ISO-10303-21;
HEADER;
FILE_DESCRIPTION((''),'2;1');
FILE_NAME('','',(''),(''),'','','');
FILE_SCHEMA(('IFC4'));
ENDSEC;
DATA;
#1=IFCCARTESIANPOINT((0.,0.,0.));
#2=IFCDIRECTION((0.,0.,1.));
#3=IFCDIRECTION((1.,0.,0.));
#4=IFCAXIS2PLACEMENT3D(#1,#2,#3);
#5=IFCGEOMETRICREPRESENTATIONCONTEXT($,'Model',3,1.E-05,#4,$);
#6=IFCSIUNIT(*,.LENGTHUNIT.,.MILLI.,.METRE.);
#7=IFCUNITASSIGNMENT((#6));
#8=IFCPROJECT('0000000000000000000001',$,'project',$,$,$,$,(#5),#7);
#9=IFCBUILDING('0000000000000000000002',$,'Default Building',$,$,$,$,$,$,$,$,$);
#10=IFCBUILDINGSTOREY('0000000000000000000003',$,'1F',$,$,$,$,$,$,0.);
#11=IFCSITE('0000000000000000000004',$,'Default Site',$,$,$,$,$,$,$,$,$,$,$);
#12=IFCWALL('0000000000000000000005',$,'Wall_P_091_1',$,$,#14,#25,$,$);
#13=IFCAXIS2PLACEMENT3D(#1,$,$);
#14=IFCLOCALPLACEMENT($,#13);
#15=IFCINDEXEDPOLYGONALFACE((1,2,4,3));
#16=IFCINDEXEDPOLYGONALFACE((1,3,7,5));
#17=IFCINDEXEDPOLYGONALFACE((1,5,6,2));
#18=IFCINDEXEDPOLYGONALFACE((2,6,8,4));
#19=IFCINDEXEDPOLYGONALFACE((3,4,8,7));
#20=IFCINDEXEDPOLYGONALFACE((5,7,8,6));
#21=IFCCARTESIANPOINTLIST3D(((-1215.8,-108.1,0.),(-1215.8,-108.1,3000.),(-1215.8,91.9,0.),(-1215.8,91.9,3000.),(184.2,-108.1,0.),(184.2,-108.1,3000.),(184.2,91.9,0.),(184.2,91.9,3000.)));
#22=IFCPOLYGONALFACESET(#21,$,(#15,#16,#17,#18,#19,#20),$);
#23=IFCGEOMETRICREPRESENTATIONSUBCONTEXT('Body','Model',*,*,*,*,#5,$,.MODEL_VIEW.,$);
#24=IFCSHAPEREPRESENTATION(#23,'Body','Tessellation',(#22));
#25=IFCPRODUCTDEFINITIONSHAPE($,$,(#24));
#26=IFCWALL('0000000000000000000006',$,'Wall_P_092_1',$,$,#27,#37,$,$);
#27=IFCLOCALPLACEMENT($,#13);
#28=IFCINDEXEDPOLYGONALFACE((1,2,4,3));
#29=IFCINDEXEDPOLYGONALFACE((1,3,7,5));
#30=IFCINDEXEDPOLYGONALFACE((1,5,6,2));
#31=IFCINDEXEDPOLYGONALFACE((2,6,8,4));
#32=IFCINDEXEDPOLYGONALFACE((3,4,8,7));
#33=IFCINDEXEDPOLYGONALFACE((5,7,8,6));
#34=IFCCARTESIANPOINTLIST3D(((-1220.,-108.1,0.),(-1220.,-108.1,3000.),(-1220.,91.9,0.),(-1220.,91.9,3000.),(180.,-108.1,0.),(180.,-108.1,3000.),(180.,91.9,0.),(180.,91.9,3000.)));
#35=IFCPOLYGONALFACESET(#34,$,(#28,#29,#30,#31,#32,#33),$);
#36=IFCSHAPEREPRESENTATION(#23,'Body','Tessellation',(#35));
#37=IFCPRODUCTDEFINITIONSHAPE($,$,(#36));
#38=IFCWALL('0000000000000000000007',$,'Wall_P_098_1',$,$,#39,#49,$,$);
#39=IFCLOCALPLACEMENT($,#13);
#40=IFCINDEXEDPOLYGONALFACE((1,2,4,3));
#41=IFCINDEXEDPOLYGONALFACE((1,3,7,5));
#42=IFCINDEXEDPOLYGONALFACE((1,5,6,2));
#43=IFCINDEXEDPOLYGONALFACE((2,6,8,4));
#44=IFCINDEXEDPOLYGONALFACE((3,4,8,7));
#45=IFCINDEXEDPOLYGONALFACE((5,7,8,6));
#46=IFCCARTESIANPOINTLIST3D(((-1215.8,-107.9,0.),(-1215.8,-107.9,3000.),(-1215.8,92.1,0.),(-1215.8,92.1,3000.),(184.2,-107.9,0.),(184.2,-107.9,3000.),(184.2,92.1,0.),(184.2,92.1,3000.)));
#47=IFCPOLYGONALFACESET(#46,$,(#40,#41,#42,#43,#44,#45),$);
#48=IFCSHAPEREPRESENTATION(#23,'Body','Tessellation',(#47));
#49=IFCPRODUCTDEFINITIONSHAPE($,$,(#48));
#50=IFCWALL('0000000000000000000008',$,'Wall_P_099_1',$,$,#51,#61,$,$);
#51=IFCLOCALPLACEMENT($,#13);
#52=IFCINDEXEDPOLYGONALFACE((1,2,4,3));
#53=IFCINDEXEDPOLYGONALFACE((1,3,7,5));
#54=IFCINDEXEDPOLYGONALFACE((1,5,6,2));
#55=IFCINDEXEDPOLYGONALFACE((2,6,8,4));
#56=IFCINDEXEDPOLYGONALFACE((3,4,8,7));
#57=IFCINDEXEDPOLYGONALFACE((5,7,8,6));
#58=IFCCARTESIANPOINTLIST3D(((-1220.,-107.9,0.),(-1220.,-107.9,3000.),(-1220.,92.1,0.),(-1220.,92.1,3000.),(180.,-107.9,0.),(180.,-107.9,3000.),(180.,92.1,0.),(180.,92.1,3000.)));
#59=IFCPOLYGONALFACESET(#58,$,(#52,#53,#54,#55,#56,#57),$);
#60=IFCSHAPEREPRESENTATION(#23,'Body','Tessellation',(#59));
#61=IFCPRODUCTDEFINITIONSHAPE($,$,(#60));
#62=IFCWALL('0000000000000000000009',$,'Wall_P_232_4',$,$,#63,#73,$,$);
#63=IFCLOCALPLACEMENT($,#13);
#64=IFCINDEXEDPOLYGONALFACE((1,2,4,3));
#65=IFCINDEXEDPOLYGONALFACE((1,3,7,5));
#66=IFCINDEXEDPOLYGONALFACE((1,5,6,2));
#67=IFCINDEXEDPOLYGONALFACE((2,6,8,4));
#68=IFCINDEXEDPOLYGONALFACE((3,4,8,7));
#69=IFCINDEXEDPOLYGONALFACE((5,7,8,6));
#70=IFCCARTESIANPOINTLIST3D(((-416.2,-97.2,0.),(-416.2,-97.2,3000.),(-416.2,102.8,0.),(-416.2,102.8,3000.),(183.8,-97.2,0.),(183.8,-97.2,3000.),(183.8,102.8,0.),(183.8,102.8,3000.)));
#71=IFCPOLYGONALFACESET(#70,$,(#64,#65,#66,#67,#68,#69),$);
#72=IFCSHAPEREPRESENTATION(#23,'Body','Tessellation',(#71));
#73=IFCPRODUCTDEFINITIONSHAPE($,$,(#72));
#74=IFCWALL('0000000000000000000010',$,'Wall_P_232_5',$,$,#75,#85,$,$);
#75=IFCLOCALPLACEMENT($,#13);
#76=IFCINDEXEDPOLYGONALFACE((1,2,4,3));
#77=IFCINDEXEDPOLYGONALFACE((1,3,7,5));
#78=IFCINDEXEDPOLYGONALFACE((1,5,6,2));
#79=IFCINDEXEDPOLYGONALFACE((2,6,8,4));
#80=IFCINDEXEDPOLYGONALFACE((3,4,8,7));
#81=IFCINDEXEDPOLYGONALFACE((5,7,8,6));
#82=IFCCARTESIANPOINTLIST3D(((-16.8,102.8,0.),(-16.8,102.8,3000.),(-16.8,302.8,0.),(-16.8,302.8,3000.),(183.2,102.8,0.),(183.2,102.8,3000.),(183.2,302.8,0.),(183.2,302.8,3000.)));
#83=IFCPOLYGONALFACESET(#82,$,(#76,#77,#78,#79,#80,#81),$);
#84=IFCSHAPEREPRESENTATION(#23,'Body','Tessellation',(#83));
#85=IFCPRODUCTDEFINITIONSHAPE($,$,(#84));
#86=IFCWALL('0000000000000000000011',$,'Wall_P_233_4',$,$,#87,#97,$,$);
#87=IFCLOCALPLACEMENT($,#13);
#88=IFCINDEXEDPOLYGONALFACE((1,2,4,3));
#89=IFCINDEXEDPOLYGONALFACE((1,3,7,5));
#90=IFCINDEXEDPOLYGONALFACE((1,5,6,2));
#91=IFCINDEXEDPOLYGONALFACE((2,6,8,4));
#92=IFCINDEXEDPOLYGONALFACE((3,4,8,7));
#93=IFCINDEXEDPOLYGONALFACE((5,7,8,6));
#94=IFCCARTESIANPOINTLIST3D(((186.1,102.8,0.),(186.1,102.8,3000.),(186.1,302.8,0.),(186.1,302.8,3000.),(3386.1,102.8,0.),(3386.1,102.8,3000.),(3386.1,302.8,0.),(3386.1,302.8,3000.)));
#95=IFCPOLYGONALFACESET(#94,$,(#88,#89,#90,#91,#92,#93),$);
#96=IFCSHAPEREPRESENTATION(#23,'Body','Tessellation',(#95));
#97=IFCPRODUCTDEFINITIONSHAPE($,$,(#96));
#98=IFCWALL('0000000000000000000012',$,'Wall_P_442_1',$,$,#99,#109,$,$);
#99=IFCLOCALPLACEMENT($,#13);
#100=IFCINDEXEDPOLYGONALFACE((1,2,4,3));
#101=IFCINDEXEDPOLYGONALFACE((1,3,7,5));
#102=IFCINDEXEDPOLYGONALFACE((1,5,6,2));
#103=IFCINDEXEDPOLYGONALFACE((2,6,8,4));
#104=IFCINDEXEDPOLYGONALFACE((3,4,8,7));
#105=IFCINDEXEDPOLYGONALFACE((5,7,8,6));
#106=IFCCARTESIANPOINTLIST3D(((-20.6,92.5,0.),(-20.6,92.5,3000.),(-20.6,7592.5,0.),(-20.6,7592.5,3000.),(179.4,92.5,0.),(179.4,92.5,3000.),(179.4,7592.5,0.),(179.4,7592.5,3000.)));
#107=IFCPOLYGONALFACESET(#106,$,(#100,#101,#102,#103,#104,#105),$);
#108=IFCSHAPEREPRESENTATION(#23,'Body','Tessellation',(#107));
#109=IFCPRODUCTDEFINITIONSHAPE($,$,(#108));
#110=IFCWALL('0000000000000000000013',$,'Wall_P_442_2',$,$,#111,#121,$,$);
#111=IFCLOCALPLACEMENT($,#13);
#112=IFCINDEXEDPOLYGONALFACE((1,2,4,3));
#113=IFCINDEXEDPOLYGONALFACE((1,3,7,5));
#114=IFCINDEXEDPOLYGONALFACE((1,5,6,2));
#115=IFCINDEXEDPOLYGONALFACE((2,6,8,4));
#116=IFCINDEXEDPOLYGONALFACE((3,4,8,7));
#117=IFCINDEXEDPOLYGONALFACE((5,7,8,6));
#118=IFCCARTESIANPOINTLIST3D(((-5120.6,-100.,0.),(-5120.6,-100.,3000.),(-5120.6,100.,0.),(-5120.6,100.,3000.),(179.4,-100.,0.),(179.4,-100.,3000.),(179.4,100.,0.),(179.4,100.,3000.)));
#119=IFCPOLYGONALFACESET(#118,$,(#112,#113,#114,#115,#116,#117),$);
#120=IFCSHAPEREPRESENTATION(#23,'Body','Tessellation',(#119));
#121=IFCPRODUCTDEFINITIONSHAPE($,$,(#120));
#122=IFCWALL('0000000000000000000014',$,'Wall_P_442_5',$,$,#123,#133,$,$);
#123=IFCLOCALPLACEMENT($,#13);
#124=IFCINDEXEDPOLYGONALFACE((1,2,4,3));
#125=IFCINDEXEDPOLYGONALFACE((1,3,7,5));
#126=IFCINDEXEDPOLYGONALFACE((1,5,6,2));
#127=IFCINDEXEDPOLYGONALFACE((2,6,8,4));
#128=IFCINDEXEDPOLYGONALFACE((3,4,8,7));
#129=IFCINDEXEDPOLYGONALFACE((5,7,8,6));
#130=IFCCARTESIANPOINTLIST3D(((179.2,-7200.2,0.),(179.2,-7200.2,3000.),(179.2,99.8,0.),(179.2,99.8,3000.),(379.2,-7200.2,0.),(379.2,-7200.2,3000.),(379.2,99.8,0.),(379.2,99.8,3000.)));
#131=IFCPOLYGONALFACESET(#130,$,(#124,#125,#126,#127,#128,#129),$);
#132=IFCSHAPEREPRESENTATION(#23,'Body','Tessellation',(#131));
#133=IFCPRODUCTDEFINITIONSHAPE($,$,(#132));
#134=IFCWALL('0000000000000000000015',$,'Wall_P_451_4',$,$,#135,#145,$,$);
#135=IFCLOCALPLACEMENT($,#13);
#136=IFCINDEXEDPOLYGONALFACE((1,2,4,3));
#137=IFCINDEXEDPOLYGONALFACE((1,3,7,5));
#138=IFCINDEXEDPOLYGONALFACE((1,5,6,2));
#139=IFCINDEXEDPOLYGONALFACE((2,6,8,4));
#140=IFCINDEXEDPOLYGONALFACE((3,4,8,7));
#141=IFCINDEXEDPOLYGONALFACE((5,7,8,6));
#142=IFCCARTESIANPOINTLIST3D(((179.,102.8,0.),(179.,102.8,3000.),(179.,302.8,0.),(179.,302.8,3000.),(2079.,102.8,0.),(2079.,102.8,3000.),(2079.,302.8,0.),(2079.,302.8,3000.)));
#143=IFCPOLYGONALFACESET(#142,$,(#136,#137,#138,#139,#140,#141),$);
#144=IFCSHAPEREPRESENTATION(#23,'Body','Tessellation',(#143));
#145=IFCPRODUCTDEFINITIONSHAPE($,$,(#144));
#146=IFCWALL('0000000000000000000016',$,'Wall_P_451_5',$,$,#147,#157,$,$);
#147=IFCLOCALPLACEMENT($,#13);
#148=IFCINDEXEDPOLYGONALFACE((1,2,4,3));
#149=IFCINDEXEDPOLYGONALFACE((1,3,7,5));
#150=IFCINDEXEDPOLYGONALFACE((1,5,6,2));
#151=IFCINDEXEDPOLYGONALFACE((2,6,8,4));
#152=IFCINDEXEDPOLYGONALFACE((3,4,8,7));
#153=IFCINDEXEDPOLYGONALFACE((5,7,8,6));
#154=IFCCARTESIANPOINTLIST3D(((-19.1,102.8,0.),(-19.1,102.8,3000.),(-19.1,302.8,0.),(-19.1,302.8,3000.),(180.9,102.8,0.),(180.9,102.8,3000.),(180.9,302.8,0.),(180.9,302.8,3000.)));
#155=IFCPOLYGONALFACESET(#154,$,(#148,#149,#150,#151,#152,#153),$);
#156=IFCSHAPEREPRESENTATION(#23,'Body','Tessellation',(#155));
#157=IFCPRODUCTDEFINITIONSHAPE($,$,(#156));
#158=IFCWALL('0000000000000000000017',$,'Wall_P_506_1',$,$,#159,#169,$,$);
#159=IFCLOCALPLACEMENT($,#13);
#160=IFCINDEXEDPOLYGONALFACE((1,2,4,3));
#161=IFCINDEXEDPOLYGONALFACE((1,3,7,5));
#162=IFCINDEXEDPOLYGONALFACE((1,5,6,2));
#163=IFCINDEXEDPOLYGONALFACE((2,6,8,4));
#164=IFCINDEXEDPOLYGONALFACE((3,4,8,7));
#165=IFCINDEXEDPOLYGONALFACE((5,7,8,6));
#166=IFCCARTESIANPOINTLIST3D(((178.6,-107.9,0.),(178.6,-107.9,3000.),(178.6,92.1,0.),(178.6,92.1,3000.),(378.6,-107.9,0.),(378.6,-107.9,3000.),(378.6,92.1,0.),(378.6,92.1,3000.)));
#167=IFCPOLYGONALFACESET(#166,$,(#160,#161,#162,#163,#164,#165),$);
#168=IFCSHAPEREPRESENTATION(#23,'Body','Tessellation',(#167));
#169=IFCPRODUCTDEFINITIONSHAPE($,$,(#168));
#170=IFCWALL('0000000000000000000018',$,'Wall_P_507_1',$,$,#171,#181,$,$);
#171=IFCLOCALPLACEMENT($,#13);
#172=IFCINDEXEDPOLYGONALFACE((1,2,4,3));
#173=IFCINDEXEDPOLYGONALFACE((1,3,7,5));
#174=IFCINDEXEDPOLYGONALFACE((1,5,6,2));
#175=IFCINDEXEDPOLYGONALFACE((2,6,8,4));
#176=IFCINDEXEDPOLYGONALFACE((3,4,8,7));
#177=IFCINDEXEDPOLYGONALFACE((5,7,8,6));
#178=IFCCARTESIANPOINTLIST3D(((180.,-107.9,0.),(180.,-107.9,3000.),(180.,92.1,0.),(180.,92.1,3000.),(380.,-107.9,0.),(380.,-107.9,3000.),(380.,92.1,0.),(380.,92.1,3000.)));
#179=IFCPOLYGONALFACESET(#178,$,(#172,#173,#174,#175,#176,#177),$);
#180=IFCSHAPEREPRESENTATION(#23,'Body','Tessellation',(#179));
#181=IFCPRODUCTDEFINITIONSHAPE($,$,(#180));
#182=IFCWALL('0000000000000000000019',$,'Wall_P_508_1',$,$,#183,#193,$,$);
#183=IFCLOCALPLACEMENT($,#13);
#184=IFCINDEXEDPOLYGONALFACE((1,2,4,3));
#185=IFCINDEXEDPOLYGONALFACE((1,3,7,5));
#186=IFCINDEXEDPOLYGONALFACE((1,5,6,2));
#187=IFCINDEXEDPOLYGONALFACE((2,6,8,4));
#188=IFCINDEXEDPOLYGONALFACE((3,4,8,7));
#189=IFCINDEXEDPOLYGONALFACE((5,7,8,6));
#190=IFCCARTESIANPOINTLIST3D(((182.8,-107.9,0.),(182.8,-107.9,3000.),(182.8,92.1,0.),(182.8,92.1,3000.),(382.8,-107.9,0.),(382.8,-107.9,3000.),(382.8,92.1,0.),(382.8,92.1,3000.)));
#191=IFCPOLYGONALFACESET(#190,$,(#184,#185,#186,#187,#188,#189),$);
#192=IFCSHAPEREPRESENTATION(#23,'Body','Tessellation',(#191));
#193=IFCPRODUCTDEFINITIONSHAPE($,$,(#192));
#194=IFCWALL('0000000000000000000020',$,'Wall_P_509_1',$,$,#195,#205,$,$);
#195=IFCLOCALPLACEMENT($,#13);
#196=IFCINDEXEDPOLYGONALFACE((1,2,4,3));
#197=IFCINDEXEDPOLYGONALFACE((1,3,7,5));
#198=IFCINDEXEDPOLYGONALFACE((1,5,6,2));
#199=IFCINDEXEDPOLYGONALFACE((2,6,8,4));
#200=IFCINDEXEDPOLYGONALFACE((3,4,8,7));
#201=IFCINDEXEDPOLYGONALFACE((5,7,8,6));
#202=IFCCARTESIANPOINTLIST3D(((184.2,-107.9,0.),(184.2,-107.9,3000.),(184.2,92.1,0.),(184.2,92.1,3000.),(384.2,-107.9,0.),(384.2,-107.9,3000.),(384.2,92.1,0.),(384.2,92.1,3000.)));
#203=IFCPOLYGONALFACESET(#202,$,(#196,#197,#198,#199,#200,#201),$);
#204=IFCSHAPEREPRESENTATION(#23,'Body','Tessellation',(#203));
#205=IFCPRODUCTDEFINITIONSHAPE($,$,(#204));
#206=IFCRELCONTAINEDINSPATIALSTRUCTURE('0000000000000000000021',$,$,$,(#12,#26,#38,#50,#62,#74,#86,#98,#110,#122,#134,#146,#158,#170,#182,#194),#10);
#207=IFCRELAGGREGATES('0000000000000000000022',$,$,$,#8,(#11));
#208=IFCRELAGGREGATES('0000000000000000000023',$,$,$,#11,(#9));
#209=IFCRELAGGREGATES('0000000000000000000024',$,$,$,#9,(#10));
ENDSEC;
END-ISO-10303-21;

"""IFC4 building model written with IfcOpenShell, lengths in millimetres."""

from ifc_helpers import new_model, si_unit, frame, origin_with_axes, place, context, subcontext, project, spatial, indexed_curve, outline, extrude, element, save


model = new_model("IFC4")

# Units and contexts
model_context = context("Model", 3, precision=1e-05, world=origin_with_axes())
body_context = subcontext(model_context, "Body", "Model", "MODEL_VIEW")
ifc_project = project(units=[si_unit("LENGTHUNIT", "METRE", prefix="MILLI")], contexts=[model_context])

# Site, building, storey
site = spatial("IfcSite", under=ifc_project, Name="Default Site")
building = spatial("IfcBuilding", under=site, Name="Default Building")
storey = spatial("IfcBuildingStorey", under=building, Name="1F", Elevation=0.0)

# Walls
wall_1_placement = place(None, frame((184.2, 91.9, 0.0), z_axis=(0.0, 0.0, 1.0), x_axis=(-1.0, 0.0, 0.0)))
element("IfcWall", 1, at=wall_1_placement, inside=storey, Name="Wall_P_091_1", context=body_context, shape_type="SweptSolid", body=[
    extrude(outline(indexed_curve([(0.0, 0.0), (0.0, 200.0), (1400.0, 200.0), (1400.0, 0.0), (0.0, 0.0)], self_intersect=False)), origin_with_axes(), (0.0, 0.0, 1.0), 3000.0),
])
wall_2_placement = place(None, frame((180.0, 91.9, 0.0), z_axis=(0.0, 0.0, 1.0), x_axis=(-1.0, 0.0, 0.0)))
element("IfcWall", 2, at=wall_2_placement, inside=storey, Name="Wall_P_092_1", context=body_context, shape_type="SweptSolid", body=[
    extrude(outline(indexed_curve([(0.0, 0.0), (0.0, 200.0), (1400.0, 200.0), (1400.0, 0.0), (0.0, 0.0)], self_intersect=False)), origin_with_axes(), (0.0, 0.0, 1.0), 3000.0),
])
wall_3_placement = place(None, frame((184.2, 92.1, 0.0), z_axis=(0.0, 0.0, 1.0), x_axis=(-1.0, 0.0, 0.0)))
element("IfcWall", 3, at=wall_3_placement, inside=storey, Name="Wall_P_098_1", context=body_context, shape_type="SweptSolid", body=[
    extrude(outline(indexed_curve([(0.0, 0.0), (0.0, 200.0), (1400.0, 200.0), (1400.0, 0.0), (0.0, 0.0)], self_intersect=False)), origin_with_axes(), (0.0, 0.0, 1.0), 3000.0),
])
wall_4_placement = place(None, frame((180.0, 92.1, 0.0), z_axis=(0.0, 0.0, 1.0), x_axis=(-1.0, 0.0, 0.0)))
element("IfcWall", 4, at=wall_4_placement, inside=storey, Name="Wall_P_099_1", context=body_context, shape_type="SweptSolid", body=[
    extrude(outline(indexed_curve([(0.0, 0.0), (0.0, 200.0), (1400.0, 200.0), (1400.0, 0.0), (0.0, 0.0)], self_intersect=False)), origin_with_axes(), (0.0, 0.0, 1.0), 3000.0),
])
wall_5_placement = place(None, frame((183.8, 102.8, 0.0), z_axis=(0.0, 0.0, 1.0), x_axis=(-1.0, 0.0, 0.0)))
element("IfcWall", 5, at=wall_5_placement, inside=storey, Name="Wall_P_232_4", context=body_context, shape_type="SweptSolid", body=[
    extrude(outline(indexed_curve([(0.0, 0.0), (0.0, 200.0), (600.0, 200.0), (600.0, 0.0), (0.0, 0.0)], self_intersect=False)), origin_with_axes(), (0.0, 0.0, 1.0), 3000.0),
])
wall_6_placement = place(None, frame((183.2, 102.8, 0.0), z_axis=(0.0, 0.0, 1.0), x_axis=(0.0, 1.0, 0.0)))
element("IfcWall", 6, at=wall_6_placement, inside=storey, Name="Wall_P_232_5", context=body_context, shape_type="SweptSolid", body=[
    extrude(outline(indexed_curve([(0.0, 0.0), (0.0, 200.0), (200.0, 200.0), (200.0, 0.0), (0.0, 0.0)], self_intersect=False)), origin_with_axes(), (0.0, 0.0, 1.0), 3000.0),
])
wall_7_placement = place(None, frame((186.1, 102.8, 0.0), z_axis=(0.0, 0.0, 1.0), x_axis=(1.0, 0.0, 0.0)))
element("IfcWall", 7, at=wall_7_placement, inside=storey, Name="Wall_P_233_4", context=body_context, shape_type="SweptSolid", body=[
    extrude(outline(indexed_curve([(0.0, 0.0), (0.0, 200.0), (3200.0, 200.0), (3200.0, 0.0), (0.0, 0.0)], self_intersect=False)), origin_with_axes(), (0.0, 0.0, 1.0), 3000.0),
])
wall_8_placement = place(None, frame((179.4, 92.5, 0.0), z_axis=(0.0, 0.0, 1.0), x_axis=(0.0, 1.0, 0.0)))
element("IfcWall", 8, at=wall_8_placement, inside=storey, Name="Wall_P_442_1", context=body_context, shape_type="SweptSolid", body=[
    extrude(outline(indexed_curve([(0.0, 0.0), (0.0, 200.0), (7500.0, 200.0), (7500.0, 0.0), (0.0, 0.0)], self_intersect=False)), origin_with_axes(), (0.0, 0.0, 1.0), 3000.0),
])
wall_9_placement = place(None, frame((179.4, 100.0, 0.0), z_axis=(0.0, 0.0, 1.0), x_axis=(-1.0, 0.0, 0.0)))
element("IfcWall", 9, at=wall_9_placement, inside=storey, Name="Wall_P_442_2", context=body_context, shape_type="SweptSolid", body=[
    extrude(outline(indexed_curve([(0.0, 0.0), (0.0, 200.0), (5300.0, 200.0), (5300.0, 0.0), (0.0, 0.0)], self_intersect=False)), origin_with_axes(), (0.0, 0.0, 1.0), 3000.0),
])
wall_10_placement = place(None, frame((179.2, 99.8, 0.0), z_axis=(0.0, 0.0, 1.0), x_axis=(0.0, -1.0, 0.0)))
element("IfcWall", 10, at=wall_10_placement, inside=storey, Name="Wall_P_442_5", context=body_context, shape_type="SweptSolid", body=[
    extrude(outline(indexed_curve([(0.0, 0.0), (0.0, 200.0), (7300.0, 200.0), (7300.0, 0.0), (0.0, 0.0)], self_intersect=False)), origin_with_axes(), (0.0, 0.0, 1.0), 3000.0),
])
wall_11_placement = place(None, frame((179.0, 102.8, 0.0), z_axis=(0.0, 0.0, 1.0), x_axis=(1.0, 0.0, 0.0)))
element("IfcWall", 11, at=wall_11_placement, inside=storey, Name="Wall_P_451_4", context=body_context, shape_type="SweptSolid", body=[
    extrude(outline(indexed_curve([(0.0, 0.0), (0.0, 200.0), (1900.0, 200.0), (1900.0, 0.0), (0.0, 0.0)], self_intersect=False)), origin_with_axes(), (0.0, 0.0, 1.0), 3000.0),
])
wall_12_placement = place(None, frame((180.9, 102.8, 0.0), z_axis=(0.0, 0.0, 1.0), x_axis=(0.0, 1.0, 0.0)))
element("IfcWall", 12, at=wall_12_placement, inside=storey, Name="Wall_P_451_5", context=body_context, shape_type="SweptSolid", body=[
    extrude(outline(indexed_curve([(0.0, 0.0), (0.0, 200.0), (200.0, 200.0), (200.0, 0.0), (0.0, 0.0)], self_intersect=False)), origin_with_axes(), (0.0, 0.0, 1.0), 3000.0),
])
wall_13_placement = place(None, frame((178.6, 92.1, 0.0), z_axis=(0.0, 0.0, 1.0), x_axis=(0.0, -1.0, 0.0)))
element("IfcWall", 13, at=wall_13_placement, inside=storey, Name="Wall_P_506_1", context=body_context, shape_type="SweptSolid", body=[
    extrude(outline(indexed_curve([(0.0, 0.0), (0.0, 200.0), (200.0, 200.0), (200.0, 0.0), (0.0, 0.0)], self_intersect=False)), origin_with_axes(), (0.0, 0.0, 1.0), 3000.0),
])
wall_14_placement = place(None, frame((180.0, 92.1, 0.0), z_axis=(0.0, 0.0, 1.0), x_axis=(0.0, -1.0, 0.0)))
element("IfcWall", 14, at=wall_14_placement, inside=storey, Name="Wall_P_507_1", context=body_context, shape_type="SweptSolid", body=[
    extrude(outline(indexed_curve([(0.0, 0.0), (0.0, 200.0), (200.0, 200.0), (200.0, 0.0), (0.0, 0.0)], self_intersect=False)), origin_with_axes(), (0.0, 0.0, 1.0), 3000.0),
])
wall_15_placement = place(None, frame((182.8, 92.1, 0.0), z_axis=(0.0, 0.0, 1.0), x_axis=(0.0, -1.0, 0.0)))
element("IfcWall", 15, at=wall_15_placement, inside=storey, Name="Wall_P_508_1", context=body_context, shape_type="SweptSolid", body=[
    extrude(outline(indexed_curve([(0.0, 0.0), (0.0, 200.0), (200.0, 200.0), (200.0, 0.0), (0.0, 0.0)], self_intersect=False)), origin_with_axes(), (0.0, 0.0, 1.0), 3000.0),
])
wall_16_placement = place(None, frame((184.2, 92.1, 0.0), z_axis=(0.0, 0.0, 1.0), x_axis=(0.0, -1.0, 0.0)))
element("IfcWall", 16, at=wall_16_placement, inside=storey, Name="Wall_P_509_1", context=body_context, shape_type="SweptSolid", body=[
    extrude(outline(indexed_curve([(0.0, 0.0), (0.0, 200.0), (200.0, 200.0), (200.0, 0.0), (0.0, 0.0)], self_intersect=False)), origin_with_axes(), (0.0, 0.0, 1.0), 3000.0),
])

save(model, "model.ifc")
